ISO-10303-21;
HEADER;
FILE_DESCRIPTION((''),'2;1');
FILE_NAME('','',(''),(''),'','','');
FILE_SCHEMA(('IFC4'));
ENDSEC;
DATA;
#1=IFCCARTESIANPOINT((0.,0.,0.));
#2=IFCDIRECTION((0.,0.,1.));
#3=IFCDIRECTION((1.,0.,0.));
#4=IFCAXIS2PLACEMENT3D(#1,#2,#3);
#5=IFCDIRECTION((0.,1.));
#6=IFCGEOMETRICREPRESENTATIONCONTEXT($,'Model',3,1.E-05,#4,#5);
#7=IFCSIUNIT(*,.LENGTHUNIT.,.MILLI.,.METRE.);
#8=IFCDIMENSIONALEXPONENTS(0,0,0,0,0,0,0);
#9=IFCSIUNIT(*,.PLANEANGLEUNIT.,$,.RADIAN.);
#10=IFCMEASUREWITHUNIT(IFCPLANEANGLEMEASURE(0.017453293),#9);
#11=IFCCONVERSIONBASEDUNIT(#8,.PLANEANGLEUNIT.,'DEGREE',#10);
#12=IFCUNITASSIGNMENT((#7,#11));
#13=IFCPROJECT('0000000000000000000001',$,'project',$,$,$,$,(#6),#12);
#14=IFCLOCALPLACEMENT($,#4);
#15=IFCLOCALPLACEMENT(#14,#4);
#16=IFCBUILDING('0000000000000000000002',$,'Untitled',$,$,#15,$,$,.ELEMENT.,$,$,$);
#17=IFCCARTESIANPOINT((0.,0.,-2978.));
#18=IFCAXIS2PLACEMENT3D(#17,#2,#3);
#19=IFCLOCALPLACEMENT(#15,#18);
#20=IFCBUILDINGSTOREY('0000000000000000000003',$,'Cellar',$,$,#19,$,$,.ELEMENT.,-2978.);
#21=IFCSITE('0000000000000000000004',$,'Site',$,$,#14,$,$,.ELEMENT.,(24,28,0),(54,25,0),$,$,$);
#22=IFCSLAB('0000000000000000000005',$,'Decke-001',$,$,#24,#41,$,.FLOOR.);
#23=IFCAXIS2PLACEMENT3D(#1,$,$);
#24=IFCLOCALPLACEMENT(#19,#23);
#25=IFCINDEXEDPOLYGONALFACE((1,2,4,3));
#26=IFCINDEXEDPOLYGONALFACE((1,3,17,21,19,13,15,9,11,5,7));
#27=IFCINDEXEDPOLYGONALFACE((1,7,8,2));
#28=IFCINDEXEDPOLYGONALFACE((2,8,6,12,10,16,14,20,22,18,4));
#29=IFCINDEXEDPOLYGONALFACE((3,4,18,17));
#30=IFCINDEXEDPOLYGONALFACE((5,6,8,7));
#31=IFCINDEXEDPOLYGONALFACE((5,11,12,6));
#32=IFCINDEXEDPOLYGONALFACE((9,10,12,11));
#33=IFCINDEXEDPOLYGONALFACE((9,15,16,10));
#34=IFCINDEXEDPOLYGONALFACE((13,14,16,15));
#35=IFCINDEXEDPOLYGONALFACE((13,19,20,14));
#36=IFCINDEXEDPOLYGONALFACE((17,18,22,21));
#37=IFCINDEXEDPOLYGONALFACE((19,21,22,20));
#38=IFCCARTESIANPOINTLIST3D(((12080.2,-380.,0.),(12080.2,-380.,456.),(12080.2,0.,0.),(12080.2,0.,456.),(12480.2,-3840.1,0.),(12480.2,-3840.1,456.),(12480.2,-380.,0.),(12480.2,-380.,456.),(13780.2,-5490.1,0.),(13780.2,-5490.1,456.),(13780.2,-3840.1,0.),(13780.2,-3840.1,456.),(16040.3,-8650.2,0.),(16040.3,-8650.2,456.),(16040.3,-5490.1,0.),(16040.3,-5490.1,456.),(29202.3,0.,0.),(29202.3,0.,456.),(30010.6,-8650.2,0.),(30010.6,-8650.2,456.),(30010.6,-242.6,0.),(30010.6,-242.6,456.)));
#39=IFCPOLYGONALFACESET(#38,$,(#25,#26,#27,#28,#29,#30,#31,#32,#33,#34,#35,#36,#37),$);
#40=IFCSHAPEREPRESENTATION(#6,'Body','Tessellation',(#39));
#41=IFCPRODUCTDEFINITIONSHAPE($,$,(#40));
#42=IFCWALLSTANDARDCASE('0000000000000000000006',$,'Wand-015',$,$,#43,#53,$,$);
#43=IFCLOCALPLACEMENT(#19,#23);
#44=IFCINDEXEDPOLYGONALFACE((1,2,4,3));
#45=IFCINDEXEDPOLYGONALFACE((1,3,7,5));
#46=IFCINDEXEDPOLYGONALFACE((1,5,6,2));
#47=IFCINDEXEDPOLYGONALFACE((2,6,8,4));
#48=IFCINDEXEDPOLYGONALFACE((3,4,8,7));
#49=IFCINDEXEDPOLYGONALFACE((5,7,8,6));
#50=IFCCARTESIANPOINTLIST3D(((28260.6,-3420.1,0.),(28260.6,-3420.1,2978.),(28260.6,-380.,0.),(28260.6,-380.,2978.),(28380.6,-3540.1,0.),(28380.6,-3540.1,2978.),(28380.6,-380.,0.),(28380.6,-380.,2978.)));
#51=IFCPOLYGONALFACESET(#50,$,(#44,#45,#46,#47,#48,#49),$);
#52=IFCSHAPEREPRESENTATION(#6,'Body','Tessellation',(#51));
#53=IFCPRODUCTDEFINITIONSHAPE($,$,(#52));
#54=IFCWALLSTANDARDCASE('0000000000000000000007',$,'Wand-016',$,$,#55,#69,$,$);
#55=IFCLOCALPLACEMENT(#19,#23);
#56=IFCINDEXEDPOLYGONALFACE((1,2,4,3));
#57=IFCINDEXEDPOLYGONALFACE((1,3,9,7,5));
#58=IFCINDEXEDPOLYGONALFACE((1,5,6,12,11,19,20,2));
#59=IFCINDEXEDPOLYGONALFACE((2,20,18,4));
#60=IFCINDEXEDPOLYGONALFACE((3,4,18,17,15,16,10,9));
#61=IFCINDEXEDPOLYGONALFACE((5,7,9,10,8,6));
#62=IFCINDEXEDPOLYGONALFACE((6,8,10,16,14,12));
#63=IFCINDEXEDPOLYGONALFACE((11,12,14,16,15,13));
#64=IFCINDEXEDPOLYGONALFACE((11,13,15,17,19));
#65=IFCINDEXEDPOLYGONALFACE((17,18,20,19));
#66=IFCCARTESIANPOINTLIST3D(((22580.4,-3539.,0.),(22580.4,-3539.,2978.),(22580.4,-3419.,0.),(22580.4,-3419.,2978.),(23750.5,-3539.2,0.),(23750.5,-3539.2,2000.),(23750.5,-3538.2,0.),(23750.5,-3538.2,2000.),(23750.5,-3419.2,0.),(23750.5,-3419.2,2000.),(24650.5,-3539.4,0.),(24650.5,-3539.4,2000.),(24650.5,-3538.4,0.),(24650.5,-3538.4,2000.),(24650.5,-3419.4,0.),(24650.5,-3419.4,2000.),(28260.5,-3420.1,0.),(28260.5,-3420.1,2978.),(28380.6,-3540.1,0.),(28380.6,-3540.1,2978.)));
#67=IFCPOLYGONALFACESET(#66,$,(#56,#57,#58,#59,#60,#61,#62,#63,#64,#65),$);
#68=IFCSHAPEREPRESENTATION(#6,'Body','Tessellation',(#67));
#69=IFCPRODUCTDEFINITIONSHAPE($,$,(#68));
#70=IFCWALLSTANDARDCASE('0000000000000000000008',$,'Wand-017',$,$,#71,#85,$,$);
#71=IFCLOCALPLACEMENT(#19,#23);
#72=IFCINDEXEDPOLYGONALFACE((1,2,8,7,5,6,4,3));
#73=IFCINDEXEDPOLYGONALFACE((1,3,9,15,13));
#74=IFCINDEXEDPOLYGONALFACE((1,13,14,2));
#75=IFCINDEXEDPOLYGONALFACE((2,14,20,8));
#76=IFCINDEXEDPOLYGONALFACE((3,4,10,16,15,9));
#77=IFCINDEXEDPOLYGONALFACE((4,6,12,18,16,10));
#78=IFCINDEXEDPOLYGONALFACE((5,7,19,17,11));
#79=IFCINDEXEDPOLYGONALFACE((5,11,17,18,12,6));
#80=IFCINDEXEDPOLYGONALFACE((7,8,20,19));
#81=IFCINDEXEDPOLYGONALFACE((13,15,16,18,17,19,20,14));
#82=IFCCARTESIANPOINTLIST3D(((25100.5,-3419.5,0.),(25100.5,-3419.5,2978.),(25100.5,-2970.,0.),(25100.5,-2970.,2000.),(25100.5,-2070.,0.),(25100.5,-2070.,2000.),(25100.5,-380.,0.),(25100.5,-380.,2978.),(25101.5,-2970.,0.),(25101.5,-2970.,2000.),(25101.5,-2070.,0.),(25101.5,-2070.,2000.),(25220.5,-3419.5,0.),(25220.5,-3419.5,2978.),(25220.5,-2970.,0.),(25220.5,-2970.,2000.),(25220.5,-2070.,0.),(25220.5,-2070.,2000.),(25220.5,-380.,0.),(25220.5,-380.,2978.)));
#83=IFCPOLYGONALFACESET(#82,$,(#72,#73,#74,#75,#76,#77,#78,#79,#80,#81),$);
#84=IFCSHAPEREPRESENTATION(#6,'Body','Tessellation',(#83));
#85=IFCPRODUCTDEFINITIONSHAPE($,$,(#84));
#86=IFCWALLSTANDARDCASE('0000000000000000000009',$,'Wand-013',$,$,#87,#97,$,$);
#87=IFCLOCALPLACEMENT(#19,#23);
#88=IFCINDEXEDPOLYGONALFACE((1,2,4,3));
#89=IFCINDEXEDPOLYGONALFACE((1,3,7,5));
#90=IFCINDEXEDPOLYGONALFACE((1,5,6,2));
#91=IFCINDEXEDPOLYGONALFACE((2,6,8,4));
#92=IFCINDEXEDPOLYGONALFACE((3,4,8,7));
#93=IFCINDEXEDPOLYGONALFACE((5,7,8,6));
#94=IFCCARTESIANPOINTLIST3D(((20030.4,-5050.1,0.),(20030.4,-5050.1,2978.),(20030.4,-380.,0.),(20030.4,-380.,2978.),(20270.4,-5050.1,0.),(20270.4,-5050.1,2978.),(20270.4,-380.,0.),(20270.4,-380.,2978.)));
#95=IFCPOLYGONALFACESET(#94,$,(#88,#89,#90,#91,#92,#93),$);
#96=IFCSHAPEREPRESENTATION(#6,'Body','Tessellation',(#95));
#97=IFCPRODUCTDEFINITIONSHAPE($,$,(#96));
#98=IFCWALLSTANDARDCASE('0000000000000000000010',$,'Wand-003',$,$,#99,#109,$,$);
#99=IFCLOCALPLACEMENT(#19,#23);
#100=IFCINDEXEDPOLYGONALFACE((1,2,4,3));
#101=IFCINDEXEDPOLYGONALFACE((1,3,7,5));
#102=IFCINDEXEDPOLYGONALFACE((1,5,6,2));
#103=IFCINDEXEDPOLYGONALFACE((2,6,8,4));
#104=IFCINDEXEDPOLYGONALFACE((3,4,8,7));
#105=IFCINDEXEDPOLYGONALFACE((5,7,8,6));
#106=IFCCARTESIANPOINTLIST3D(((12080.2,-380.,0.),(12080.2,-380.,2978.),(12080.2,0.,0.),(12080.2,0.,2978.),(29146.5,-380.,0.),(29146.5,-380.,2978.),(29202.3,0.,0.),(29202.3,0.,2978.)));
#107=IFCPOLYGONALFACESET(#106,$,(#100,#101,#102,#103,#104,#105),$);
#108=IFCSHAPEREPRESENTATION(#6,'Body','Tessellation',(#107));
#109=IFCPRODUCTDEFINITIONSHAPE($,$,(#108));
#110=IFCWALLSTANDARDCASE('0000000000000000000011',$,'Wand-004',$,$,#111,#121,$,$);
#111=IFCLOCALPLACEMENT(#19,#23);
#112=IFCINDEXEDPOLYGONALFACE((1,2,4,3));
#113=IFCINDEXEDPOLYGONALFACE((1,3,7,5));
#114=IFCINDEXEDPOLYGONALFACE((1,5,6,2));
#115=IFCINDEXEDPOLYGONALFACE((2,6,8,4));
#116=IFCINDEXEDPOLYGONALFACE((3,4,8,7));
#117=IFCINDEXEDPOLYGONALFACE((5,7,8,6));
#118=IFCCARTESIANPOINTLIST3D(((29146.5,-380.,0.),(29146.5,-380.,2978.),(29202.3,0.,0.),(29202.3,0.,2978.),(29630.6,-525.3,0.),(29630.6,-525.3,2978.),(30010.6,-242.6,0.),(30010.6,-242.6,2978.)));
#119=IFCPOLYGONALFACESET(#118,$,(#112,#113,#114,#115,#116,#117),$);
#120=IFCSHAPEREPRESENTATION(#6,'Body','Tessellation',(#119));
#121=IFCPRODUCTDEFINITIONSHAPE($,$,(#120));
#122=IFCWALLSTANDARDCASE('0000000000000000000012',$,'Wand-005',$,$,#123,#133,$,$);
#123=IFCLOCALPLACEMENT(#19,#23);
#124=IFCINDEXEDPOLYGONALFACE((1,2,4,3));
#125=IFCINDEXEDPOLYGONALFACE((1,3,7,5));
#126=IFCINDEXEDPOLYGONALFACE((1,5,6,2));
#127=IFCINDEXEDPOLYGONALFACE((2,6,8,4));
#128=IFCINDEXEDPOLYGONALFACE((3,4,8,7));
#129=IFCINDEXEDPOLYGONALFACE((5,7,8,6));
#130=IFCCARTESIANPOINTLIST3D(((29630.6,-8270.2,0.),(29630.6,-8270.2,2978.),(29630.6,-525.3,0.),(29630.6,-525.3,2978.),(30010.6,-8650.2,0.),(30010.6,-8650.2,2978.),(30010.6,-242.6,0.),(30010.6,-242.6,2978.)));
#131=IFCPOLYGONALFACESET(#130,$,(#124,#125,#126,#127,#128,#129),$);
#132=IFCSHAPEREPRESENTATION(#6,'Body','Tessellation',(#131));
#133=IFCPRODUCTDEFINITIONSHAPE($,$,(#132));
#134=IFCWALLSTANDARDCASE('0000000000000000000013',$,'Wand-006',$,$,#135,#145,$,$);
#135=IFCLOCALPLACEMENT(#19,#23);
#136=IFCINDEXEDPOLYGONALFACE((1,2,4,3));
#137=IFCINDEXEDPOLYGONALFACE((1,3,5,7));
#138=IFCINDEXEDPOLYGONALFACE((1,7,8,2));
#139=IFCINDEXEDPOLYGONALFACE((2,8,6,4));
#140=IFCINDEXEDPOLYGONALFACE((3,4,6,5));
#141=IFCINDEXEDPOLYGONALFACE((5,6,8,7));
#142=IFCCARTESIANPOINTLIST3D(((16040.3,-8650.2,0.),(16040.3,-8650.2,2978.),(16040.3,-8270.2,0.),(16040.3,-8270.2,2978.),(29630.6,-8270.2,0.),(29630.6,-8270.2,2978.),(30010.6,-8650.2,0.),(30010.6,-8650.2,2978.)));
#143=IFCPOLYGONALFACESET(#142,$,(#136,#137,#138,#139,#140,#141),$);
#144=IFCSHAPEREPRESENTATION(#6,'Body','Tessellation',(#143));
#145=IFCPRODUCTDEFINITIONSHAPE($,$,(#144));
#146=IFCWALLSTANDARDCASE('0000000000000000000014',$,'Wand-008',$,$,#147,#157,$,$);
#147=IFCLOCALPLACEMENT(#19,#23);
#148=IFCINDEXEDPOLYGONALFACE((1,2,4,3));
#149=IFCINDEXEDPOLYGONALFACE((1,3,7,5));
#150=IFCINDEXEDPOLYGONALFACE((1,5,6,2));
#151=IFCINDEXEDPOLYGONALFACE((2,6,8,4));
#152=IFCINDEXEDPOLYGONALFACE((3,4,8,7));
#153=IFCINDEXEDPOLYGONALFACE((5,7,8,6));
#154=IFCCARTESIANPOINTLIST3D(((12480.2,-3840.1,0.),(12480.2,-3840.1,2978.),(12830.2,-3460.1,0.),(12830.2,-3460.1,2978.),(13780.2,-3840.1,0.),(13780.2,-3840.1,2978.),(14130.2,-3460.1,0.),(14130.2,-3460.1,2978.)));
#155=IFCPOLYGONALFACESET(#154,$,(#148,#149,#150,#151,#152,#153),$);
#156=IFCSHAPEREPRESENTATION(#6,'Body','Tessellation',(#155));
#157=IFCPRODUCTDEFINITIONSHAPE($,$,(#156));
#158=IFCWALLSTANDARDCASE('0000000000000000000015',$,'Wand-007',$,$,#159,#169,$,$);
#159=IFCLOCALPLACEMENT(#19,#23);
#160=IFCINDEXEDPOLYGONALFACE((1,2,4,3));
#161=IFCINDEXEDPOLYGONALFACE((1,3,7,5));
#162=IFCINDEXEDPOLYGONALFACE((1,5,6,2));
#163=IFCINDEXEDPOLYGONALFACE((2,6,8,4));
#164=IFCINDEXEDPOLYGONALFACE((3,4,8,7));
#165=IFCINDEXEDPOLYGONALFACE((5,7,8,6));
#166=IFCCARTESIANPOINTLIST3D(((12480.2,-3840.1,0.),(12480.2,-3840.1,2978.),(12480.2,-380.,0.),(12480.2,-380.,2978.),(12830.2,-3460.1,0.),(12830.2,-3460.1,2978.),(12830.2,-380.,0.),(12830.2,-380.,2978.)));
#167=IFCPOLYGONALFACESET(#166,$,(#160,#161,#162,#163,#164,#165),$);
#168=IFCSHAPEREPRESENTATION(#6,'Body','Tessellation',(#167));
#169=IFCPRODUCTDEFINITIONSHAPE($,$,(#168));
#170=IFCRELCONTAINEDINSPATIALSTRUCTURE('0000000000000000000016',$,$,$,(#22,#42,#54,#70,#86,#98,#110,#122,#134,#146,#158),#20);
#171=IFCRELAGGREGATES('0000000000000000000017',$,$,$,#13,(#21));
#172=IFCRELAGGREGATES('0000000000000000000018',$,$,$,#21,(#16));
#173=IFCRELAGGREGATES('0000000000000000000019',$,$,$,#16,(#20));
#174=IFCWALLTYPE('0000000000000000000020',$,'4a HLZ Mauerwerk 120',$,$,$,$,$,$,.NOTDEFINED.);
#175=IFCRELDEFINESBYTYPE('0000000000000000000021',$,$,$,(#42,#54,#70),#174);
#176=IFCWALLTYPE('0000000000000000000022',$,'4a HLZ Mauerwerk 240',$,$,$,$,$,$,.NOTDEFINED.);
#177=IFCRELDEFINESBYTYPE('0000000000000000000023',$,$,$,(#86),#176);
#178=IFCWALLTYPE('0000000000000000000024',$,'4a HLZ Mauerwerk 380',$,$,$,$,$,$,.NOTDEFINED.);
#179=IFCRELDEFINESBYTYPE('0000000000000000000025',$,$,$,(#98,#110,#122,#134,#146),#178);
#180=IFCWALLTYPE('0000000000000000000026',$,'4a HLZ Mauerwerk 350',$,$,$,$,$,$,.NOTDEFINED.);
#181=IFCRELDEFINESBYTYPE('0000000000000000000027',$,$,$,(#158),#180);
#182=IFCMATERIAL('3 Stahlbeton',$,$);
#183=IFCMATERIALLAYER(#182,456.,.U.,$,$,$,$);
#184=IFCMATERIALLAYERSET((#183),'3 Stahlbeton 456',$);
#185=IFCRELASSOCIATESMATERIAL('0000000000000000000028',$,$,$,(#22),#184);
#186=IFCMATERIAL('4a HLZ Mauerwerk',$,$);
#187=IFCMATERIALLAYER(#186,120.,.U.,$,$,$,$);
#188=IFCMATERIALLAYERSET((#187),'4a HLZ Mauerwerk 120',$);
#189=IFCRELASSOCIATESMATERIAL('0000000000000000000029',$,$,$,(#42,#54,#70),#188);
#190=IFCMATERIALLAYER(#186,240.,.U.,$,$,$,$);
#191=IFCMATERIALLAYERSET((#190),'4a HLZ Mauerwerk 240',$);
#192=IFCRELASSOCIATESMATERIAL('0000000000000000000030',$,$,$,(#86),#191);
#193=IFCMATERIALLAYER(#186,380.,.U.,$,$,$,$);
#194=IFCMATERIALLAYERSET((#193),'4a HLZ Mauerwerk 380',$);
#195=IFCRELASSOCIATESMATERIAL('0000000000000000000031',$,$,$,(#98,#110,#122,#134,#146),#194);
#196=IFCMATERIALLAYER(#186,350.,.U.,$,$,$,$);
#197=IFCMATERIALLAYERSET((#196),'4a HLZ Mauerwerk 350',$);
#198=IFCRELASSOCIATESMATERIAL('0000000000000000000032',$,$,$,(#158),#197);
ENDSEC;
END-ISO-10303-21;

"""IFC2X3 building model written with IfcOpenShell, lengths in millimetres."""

from ifc_helpers import new_model, entity, si_unit, converted_unit, direction, frame, origin_with_axes, origin_2d_with_axis, place, context, project, spatial, polyline, rectangle, outline, extrude, material, layer, layer_set, layer_usage, type_object, element, save


model = new_model("IFC2X3")

# Units and contexts
model_context = context("Model", 3, precision=1e-05, world=origin_with_axes(), true_north=direction((0.0, 1.0)))
ifc_project = project(units=[si_unit("LENGTHUNIT", "METRE", prefix="MILLI"), converted_unit("PLANEANGLEUNIT", "DEGREE", entity("IfcPlaneAngleMeasure", 0.017453293), si_unit("PLANEANGLEUNIT", "RADIAN"), dimensions=[0, 0, 0, 0, 0, 0, 0])], contexts=[model_context])

# Site, building, storey
site_placement = place(None, origin_with_axes())
site = spatial("IfcSite", under=ifc_project, at=site_placement, Name="Site", CompositionType="ELEMENT", RefLatitude=(24, 28, 0), RefLongitude=(54, 25, 0))
building_placement = place(site_placement, origin_with_axes())
building = spatial("IfcBuilding", under=site, at=building_placement, Name="Untitled", CompositionType="ELEMENT")
storey_placement = place(building_placement, frame((0.0, 0.0, -2978.0), z_axis=(0.0, 0.0, 1.0), x_axis=(1.0, 0.0, 0.0)))
storey = spatial("IfcBuildingStorey", under=building, at=storey_placement, Name="Cellar", CompositionType="ELEMENT", Elevation=-2978.0)

# Slab
ifc_material_1 = material(Name="3 Stahlbeton")
ifc_layer_1 = layer(ifc_material_1, 456.0, ventilated="UNKNOWN")
ifc_layer_set_1 = layer_set([ifc_layer_1], Name="3 Stahlbeton 456")
ifc_layer_usage_1 = layer_usage(ifc_layer_set_1, "AXIS3", "NEGATIVE", 456.0)
slab_placement = place(storey_placement, frame((12080.2, 0.0, 0.0), z_axis=(0.0, 0.0, 1.0), x_axis=(1.0, 0.0, 0.0)))
element("IfcSlab", 1, at=slab_placement, inside=storey, material=ifc_layer_usage_1, Name="Decke-001", PredefinedType="FLOOR", context=model_context, shape_type="SweptSolid", body=[
    extrude(outline(polyline([(0.0, 0.0), (0.0, -380.0), (400.0, -380.0), (400.0, -3840.1), (1700.0, -3840.1), (1700.0, -5490.1), (3960.1, -5490.1), (3960.1, -8650.2), (17930.4, -8650.2), (17930.4, -242.6), (17122.1, 0.0), (0.0, 0.0)])), origin_with_axes(), (0.0, 0.0, 1.0), 456.0),
])

# Wall
ifc_material_2 = material(Name="4a HLZ Mauerwerk")
ifc_layer_2 = layer(ifc_material_2, 120.0, ventilated="UNKNOWN")
ifc_layer_set_2 = layer_set([ifc_layer_2], Name="4a HLZ Mauerwerk 120")
ifc_layer_usage_2 = layer_usage(ifc_layer_set_2, "AXIS2", "NEGATIVE", 0.0)
wall_type_1 = type_object("IfcWallType", Name="4a HLZ Mauerwerk 120", PredefinedType="NOTDEFINED")
wall_1_placement = place(storey_placement, frame((28380.5, 0.0, 0.0), z_axis=(0.0, 0.0, 1.0), x_axis=(0.0, -1.0, 0.0)))
element("IfcWallStandardCase", 2, at=wall_1_placement, inside=storey, type_object=wall_type_1, material=ifc_layer_usage_2, Name="Wand-015", context=model_context, shape_type="SweptSolid", body=[
    extrude(outline(polyline([(380.0, -120.0), (3420.1, -120.0), (3540.1, 0.0), (380.0, 0.0), (380.0, -120.0)])), origin_with_axes(), (0.0, 0.0, 1.0), 2978.0),
])

# Walls, openings
ifc_layer_usage_3 = layer_usage(ifc_layer_set_2, "AXIS2", "NEGATIVE", 0.0)
wall_2_placement = place(storey_placement, frame((28380.5, -3540.1, 0.0), z_axis=(0.0, 0.0, 1.0), x_axis=(-1.0, 0.000181, 0.0)))
wall_2 = element("IfcWallStandardCase", 3, at=wall_2_placement, inside=storey, type_object=wall_type_1, material=ifc_layer_usage_3, Name="Wand-016", context=model_context, shape_type="SweptSolid", body=[
    extrude(outline(polyline([(120.0, -120.0), (5800.2, -120.0), (5800.1, 0.0), (0.0, 0.0), (120.0, -120.0)])), origin_with_axes(), (0.0, 0.0, 1.0), 2978.0),
])
opening_1_placement = place(wall_2_placement, frame((4180.1, 0.0, 0.0), z_axis=(0.0, 0.0, 1.0), x_axis=(1.0, 0.0, 0.0)))
element("IfcOpeningElement", 4, at=opening_1_placement, cuts=wall_2, context=model_context, shape_type="SweptSolid", body=[
    extrude(rectangle(XDim=900.0, YDim=2000.0, at=origin_2d_with_axis()), frame((0.0, 241.0, 1000.0), z_axis=(0.0, -1.0, 0.0), x_axis=(1.0, 0.0, 0.0)), (0.0, 0.0, 1.0), 242.0),
    extrude(rectangle(XDim=900.0, YDim=2000.0, at=origin_2d_with_axis()), frame((0.0, -241.0, 1000.0), z_axis=(0.0, 1.0, 0.0), x_axis=(1.0, 0.0, 0.0)), (0.0, 0.0, 1.0), 242.0),
])
ifc_layer_usage_4 = layer_usage(ifc_layer_set_2, "AXIS2", "POSITIVE", 0.0)
wall_3_placement = place(storey_placement, frame((25100.5, 0.0, 0.0), z_axis=(0.0, 0.0, 1.0), x_axis=(0.0, -1.0, 0.0)))
wall_3 = element("IfcWallStandardCase", 5, at=wall_3_placement, inside=storey, type_object=wall_type_1, material=ifc_layer_usage_4, Name="Wand-017", context=model_context, shape_type="SweptSolid", body=[
    extrude(outline(polyline([(380.0, 0.0), (3419.5, 0.0), (3419.5, 120.0), (380.0, 120.0), (380.0, 0.0)])), origin_with_axes(), (0.0, 0.0, 1.0), 2978.0),
])
opening_2_placement = place(wall_3_placement, frame((2520.0, 0.0, 0.0), z_axis=(0.0, 0.0, 1.0), x_axis=(1.0, 0.0, 0.0)))
element("IfcOpeningElement", 6, at=opening_2_placement, cuts=wall_3, context=model_context, shape_type="SweptSolid", body=[
    extrude(rectangle(XDim=900.0, YDim=2000.0, at=origin_2d_with_axis()), frame((0.0, -241.0, 1000.0), z_axis=(0.0, 1.0, 0.0), x_axis=(1.0, 0.0, 0.0)), (0.0, 0.0, 1.0), 242.0),
    extrude(rectangle(XDim=900.0, YDim=2000.0, at=origin_2d_with_axis()), frame((0.0, 241.0, 1000.0), z_axis=(0.0, -1.0, 0.0), x_axis=(1.0, 0.0, 0.0)), (0.0, 0.0, 1.0), 242.0),
])

# Walls
ifc_layer_3 = layer(ifc_material_2, 240.0, ventilated="UNKNOWN")
ifc_layer_set_3 = layer_set([ifc_layer_3], Name="4a HLZ Mauerwerk 240")
ifc_layer_usage_5 = layer_usage(ifc_layer_set_3, "AXIS2", "POSITIVE", 0.0)
wall_type_2 = type_object("IfcWallType", Name="4a HLZ Mauerwerk 240", PredefinedType="NOTDEFINED")
wall_4_placement = place(storey_placement, frame((20030.4, 0.0, 0.0), z_axis=(0.0, 0.0, 1.0), x_axis=(0.0, -1.0, 0.0)))
element("IfcWallStandardCase", 7, at=wall_4_placement, inside=storey, type_object=wall_type_2, material=ifc_layer_usage_5, Name="Wand-013", context=model_context, shape_type="SweptSolid", body=[
    extrude(outline(polyline([(380.0, 0.0), (5050.1, 0.0), (5050.1, 240.0), (380.0, 240.0), (380.0, 0.0)])), origin_with_axes(), (0.0, 0.0, 1.0), 2978.0),
])
ifc_layer_4 = layer(ifc_material_2, 380.0, ventilated="UNKNOWN")
ifc_layer_set_4 = layer_set([ifc_layer_4], Name="4a HLZ Mauerwerk 380")
ifc_layer_usage_6 = layer_usage(ifc_layer_set_4, "AXIS2", "NEGATIVE", 0.0)
wall_type_3 = type_object("IfcWallType", Name="4a HLZ Mauerwerk 380", PredefinedType="NOTDEFINED")
wall_5_placement = place(storey_placement, frame((12080.2, 0.0, 0.0), z_axis=(0.0, 0.0, 1.0), x_axis=(1.0, 0.0, 0.0)))
element("IfcWallStandardCase", 8, at=wall_5_placement, inside=storey, type_object=wall_type_3, material=ifc_layer_usage_6, Name="Wand-003", context=model_context, shape_type="SweptSolid", body=[
    extrude(outline(polyline([(0.0, -380.0), (17066.3, -380.0), (17122.1, 0.0), (0.0, 0.0), (0.0, -380.0)])), origin_with_axes(), (0.0, 0.0, 1.0), 2978.0),
])
ifc_layer_usage_7 = layer_usage(ifc_layer_set_4, "AXIS2", "NEGATIVE", 0.0)
wall_6_placement = place(storey_placement, frame((29202.3, 0.0, 0.0), z_axis=(0.0, 0.0, 1.0), x_axis=(0.957788, -0.287475, 0.0)))
element("IfcWallStandardCase", 9, at=wall_6_placement, inside=storey, type_object=wall_type_3, material=ifc_layer_usage_7, Name="Wand-004", context=model_context, shape_type="SweptSolid", body=[
    extrude(outline(polyline([(55.8, -380.0), (561.2, -380.0), (843.9, 0.0), (0.0, 0.0), (55.8, -380.0)])), origin_with_axes(), (0.0, 0.0, 1.0), 2978.0),
])
ifc_layer_usage_8 = layer_usage(ifc_layer_set_4, "AXIS2", "NEGATIVE", 0.0)
wall_7_placement = place(storey_placement, frame((30010.6, -242.6, 0.0), z_axis=(0.0, 0.0, 1.0), x_axis=(0.0, -1.0, 0.0)))
element("IfcWallStandardCase", 10, at=wall_7_placement, inside=storey, type_object=wall_type_3, material=ifc_layer_usage_8, Name="Wand-005", context=model_context, shape_type="SweptSolid", body=[
    extrude(outline(polyline([(282.7, -380.0), (8027.6, -380.0), (8407.6, 0.0), (0.0, 0.0), (282.7, -380.0)])), origin_with_axes(), (0.0, 0.0, 1.0), 2978.0),
])
ifc_layer_usage_9 = layer_usage(ifc_layer_set_4, "AXIS2", "NEGATIVE", 0.0)
wall_8_placement = place(storey_placement, frame((30010.6, -8650.2, 0.0), z_axis=(0.0, 0.0, 1.0), x_axis=(-1.0, 0.0, 0.0)))
element("IfcWallStandardCase", 11, at=wall_8_placement, inside=storey, type_object=wall_type_3, material=ifc_layer_usage_9, Name="Wand-006", context=model_context, shape_type="SweptSolid", body=[
    extrude(outline(polyline([(380.0, -380.0), (13970.3, -380.0), (13970.3, 0.0), (0.0, 0.0), (380.0, -380.0)])), origin_with_axes(), (0.0, 0.0, 1.0), 2978.0),
])
ifc_layer_usage_10 = layer_usage(ifc_layer_set_4, "AXIS2", "POSITIVE", 0.0)
wall_9_placement = place(storey_placement, frame((12480.2, -3840.1, 0.0), z_axis=(0.0, 0.0, 1.0), x_axis=(1.0, 0.0, 0.0)))
element("IfcWallStandardCase", 12, at=wall_9_placement, inside=storey, type_object=wall_type_3, material=ifc_layer_usage_10, Name="Wand-008", context=model_context, shape_type="SweptSolid", body=[
    extrude(outline(polyline([(0.0, 0.0), (1300.0, 0.0), (1650.0, 380.0), (350.0, 380.0), (0.0, 0.0)])), origin_with_axes(), (0.0, 0.0, 1.0), 2978.0),
])
ifc_layer_5 = layer(ifc_material_2, 350.0, ventilated="UNKNOWN")
ifc_layer_set_5 = layer_set([ifc_layer_5], Name="4a HLZ Mauerwerk 350")
ifc_layer_usage_11 = layer_usage(ifc_layer_set_5, "AXIS2", "POSITIVE", 0.0)
wall_type_4 = type_object("IfcWallType", Name="4a HLZ Mauerwerk 350", PredefinedType="NOTDEFINED")
wall_10_placement = place(storey_placement, frame((12480.2, 0.0, 0.0), z_axis=(0.0, 0.0, 1.0), x_axis=(0.0, -1.0, 0.0)))
element("IfcWallStandardCase", 13, at=wall_10_placement, inside=storey, type_object=wall_type_4, material=ifc_layer_usage_11, Name="Wand-007", context=model_context, shape_type="SweptSolid", body=[
    extrude(outline(polyline([(380.0, 0.0), (3840.1, 0.0), (3460.1, 350.0), (380.0, 350.0), (380.0, 0.0)])), origin_with_axes(), (0.0, 0.0, 1.0), 2978.0),
])

save(model, "model.ifc")
